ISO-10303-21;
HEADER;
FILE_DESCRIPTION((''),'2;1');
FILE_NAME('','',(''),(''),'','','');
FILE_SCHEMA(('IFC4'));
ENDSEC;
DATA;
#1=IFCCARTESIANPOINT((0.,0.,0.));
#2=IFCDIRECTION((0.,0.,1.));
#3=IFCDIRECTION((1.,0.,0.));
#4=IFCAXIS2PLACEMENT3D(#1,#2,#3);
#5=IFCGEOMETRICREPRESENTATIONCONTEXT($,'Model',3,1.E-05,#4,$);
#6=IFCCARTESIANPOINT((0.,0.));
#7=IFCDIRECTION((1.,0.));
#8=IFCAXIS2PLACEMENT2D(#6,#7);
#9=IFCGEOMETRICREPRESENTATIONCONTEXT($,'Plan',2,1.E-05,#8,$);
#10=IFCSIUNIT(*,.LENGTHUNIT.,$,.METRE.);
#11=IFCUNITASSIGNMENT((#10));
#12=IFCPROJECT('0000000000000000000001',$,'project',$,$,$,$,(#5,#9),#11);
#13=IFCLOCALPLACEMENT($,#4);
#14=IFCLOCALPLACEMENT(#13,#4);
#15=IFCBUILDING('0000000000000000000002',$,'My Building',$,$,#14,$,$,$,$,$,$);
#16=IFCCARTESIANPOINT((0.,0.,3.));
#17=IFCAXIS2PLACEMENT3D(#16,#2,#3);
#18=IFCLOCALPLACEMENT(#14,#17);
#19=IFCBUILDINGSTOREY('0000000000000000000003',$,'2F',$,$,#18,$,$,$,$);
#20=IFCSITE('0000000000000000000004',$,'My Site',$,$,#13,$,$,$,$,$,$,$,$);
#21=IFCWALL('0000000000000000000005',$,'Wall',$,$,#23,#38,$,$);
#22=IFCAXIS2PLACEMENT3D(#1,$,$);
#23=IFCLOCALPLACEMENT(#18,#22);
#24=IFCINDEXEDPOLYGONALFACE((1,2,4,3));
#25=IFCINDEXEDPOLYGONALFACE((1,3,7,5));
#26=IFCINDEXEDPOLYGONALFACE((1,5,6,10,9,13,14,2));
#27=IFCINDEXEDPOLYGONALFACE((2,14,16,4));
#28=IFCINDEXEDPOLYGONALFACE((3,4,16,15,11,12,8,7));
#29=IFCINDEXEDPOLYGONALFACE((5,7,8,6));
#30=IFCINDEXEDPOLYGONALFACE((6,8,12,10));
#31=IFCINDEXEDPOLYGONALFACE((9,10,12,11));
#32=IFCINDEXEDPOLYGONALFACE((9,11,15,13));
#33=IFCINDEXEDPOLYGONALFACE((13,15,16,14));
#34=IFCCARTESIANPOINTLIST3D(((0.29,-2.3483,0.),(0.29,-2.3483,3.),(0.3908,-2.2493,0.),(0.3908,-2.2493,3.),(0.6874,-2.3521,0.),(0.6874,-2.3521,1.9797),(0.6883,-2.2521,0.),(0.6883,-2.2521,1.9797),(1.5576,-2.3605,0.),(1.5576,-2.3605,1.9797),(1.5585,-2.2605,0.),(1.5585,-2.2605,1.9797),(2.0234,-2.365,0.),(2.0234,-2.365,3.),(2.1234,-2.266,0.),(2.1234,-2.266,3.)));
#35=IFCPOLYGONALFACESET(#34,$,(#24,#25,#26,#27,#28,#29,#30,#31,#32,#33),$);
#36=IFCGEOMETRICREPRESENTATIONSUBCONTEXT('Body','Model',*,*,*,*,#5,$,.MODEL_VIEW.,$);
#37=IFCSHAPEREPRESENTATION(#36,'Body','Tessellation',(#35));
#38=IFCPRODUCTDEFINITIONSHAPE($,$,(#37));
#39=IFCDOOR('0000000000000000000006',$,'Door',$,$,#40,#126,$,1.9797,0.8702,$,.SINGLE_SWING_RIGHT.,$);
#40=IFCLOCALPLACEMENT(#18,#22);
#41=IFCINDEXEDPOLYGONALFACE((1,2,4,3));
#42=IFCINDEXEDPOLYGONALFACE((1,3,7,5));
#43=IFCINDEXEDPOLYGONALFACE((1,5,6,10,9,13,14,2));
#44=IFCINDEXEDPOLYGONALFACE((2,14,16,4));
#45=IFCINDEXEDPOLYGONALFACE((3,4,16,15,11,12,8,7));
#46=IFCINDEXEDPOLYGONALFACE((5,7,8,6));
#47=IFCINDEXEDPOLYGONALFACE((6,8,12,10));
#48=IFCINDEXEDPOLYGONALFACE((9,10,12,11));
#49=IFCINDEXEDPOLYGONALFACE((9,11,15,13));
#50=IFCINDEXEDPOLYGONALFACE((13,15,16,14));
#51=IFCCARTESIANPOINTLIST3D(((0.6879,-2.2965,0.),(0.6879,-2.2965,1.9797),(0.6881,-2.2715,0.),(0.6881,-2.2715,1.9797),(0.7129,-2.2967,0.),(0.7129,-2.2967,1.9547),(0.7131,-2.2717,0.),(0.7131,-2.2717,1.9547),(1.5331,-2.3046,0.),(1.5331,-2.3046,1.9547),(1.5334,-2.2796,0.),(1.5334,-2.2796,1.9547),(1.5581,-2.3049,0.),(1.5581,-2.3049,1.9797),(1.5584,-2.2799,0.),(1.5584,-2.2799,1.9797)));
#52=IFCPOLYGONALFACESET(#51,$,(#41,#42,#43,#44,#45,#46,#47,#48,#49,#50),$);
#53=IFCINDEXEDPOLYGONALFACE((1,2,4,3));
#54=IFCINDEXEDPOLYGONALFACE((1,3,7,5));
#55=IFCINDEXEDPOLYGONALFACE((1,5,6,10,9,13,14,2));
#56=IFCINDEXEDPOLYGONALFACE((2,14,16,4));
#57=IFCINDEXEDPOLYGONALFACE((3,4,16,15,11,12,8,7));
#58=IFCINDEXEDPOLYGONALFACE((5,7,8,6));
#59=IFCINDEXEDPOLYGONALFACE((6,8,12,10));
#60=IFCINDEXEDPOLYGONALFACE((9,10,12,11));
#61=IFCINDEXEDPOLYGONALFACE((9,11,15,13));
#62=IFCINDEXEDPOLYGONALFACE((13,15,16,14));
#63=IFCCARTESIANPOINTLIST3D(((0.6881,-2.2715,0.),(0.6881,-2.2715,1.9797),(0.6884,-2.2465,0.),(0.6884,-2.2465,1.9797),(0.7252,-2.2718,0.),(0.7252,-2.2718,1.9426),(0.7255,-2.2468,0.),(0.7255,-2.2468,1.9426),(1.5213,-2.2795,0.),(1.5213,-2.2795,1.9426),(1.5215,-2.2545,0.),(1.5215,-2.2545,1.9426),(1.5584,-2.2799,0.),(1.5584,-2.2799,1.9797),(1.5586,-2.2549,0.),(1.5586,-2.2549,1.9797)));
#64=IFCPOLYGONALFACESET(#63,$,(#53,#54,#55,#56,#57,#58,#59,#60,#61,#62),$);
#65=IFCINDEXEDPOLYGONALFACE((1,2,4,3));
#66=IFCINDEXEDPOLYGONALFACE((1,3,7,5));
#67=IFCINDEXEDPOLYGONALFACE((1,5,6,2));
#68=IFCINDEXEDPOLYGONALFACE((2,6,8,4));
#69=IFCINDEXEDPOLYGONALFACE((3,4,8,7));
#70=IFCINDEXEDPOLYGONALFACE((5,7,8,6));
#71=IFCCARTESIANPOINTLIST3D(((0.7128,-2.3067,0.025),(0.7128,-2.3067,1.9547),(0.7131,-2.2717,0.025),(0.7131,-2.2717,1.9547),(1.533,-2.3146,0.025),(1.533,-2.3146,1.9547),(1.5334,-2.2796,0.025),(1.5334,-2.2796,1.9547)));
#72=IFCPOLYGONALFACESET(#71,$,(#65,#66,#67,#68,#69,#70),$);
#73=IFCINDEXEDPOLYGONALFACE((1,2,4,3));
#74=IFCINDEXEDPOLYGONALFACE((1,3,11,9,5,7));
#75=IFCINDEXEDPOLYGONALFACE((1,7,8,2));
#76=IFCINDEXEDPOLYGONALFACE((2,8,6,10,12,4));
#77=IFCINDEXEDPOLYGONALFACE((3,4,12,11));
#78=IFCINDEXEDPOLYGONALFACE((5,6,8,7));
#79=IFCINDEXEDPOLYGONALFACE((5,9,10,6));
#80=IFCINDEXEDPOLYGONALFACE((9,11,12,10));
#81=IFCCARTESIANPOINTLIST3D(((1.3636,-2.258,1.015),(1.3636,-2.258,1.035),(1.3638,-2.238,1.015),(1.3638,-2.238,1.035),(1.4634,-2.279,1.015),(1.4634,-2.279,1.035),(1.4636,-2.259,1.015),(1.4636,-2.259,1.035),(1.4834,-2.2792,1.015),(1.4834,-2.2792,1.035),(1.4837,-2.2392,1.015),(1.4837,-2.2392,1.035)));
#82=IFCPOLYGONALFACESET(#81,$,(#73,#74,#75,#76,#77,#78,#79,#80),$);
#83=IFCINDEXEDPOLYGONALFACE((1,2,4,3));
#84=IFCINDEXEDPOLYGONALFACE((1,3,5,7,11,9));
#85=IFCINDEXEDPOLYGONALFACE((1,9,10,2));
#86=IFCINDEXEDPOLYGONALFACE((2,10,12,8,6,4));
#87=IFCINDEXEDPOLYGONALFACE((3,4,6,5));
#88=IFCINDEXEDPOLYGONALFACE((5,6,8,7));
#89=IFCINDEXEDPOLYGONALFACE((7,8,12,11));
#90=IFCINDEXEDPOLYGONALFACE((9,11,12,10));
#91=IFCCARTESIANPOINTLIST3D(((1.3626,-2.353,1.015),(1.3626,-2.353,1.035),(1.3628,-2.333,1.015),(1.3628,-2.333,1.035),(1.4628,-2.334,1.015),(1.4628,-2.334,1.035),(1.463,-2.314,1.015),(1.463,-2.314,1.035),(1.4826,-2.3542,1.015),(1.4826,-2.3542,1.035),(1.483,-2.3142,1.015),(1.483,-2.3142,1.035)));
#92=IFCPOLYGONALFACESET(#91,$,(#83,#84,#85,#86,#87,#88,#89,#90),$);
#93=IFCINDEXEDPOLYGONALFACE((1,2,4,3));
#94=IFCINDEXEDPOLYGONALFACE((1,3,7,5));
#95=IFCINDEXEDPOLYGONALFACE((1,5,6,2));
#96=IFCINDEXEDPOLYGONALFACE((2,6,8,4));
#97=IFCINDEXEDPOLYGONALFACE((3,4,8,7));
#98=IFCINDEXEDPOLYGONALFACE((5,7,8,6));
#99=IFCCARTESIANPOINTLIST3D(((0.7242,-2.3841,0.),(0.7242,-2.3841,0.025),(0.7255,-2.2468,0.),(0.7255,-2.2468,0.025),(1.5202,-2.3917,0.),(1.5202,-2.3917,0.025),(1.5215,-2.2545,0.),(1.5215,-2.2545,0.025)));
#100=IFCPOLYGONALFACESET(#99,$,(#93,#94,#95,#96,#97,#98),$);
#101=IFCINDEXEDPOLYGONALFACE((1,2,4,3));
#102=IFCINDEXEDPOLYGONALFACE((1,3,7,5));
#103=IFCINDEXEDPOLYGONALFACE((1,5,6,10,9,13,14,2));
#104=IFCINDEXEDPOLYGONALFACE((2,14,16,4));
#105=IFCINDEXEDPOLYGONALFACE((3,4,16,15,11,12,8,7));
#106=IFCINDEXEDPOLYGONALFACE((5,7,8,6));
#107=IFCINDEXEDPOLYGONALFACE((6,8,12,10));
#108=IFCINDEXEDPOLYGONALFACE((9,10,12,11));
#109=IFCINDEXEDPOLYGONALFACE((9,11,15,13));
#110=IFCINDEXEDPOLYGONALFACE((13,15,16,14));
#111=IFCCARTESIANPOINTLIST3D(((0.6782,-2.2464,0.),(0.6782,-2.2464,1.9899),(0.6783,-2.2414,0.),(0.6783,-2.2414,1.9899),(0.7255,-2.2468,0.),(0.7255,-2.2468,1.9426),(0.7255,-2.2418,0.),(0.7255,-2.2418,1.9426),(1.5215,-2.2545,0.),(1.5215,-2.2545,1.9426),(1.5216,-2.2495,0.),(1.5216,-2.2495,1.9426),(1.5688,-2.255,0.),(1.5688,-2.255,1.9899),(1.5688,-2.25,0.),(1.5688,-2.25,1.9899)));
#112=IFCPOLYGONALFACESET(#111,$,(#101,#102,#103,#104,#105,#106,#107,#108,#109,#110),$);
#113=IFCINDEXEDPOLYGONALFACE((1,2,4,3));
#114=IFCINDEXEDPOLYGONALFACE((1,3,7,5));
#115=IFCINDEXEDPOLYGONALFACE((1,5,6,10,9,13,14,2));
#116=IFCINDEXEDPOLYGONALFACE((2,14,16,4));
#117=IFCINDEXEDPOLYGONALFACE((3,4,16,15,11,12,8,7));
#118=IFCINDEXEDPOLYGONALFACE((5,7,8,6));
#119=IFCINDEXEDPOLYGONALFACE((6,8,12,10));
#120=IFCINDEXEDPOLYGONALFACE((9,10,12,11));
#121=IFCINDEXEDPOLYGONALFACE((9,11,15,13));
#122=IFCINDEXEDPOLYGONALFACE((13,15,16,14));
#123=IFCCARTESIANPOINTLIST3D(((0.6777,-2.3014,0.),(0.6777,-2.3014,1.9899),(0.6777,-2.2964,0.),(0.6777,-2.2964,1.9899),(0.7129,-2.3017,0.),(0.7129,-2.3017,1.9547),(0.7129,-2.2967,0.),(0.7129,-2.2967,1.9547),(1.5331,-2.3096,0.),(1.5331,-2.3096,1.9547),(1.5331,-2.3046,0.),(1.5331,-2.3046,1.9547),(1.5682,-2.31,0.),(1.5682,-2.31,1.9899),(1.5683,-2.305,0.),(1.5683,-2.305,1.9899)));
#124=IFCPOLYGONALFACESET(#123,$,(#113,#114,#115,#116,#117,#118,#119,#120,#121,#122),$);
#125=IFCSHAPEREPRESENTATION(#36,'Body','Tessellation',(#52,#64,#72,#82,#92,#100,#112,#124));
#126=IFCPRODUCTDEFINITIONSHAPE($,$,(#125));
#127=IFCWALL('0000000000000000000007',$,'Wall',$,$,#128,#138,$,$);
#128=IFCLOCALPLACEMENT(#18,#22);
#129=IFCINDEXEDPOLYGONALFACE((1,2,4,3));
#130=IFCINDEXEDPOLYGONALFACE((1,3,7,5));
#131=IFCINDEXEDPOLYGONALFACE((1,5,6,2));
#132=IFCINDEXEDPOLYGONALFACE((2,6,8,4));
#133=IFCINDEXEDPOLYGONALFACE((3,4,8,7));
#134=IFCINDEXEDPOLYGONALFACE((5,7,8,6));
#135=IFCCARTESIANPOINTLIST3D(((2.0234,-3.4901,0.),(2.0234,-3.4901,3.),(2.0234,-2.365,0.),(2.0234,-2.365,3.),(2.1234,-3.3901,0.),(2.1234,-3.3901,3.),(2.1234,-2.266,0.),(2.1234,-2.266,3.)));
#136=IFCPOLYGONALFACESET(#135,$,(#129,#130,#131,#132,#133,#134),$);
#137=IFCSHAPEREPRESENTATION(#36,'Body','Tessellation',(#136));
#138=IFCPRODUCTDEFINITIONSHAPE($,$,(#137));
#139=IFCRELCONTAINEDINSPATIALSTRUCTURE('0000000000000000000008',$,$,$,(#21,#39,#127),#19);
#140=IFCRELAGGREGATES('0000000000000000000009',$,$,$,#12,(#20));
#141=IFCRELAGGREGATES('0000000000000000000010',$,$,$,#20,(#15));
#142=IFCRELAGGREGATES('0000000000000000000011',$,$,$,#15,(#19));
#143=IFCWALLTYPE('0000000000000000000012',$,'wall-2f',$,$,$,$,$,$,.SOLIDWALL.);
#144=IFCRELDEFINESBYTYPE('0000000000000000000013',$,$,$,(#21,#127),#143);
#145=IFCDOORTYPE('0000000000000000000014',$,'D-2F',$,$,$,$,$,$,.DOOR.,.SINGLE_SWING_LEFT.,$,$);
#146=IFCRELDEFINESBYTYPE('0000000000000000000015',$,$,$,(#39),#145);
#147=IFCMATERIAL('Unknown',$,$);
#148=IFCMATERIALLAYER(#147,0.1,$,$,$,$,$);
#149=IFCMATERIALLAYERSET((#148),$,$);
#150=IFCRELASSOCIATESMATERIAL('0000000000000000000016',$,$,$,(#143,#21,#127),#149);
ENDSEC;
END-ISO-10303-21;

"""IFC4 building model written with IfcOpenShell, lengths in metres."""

from ifc_helpers import new_model, entity, si_unit, frame, origin_with_axes, origin_2d_with_axis, place, context, subcontext, project, spatial, line, indexed_curve, outline, extrude, shape, source, transform, mapped, material, layer, layer_set, layer_usage, type_object, type_shapes, element, fill, save


model = new_model("IFC4")

# Units and contexts
model_context = context("Model", 3, precision=1e-05, world=origin_with_axes())
plan_context = context("Plan", 2, precision=1e-05, world=origin_2d_with_axis())
body_context_1 = subcontext(model_context, "Body", "Model", "MODEL_VIEW")
body_context_2 = subcontext(plan_context, "Body", "Plan", "PLAN_VIEW")
ifc_project = project(units=[si_unit("LENGTHUNIT", "METRE")], contexts=[model_context, plan_context])

# Site, building, storey
site_placement = place(None, origin_with_axes())
site = spatial("IfcSite", under=ifc_project, at=site_placement, Name="My Site")
building_placement = place(site_placement, origin_with_axes())
building = spatial("IfcBuilding", under=site, at=building_placement, Name="My Building")
storey_placement = place(building_placement, frame((0.0, 0.0, 3.0), z_axis=(0.0, 0.0, 1.0), x_axis=(1.0, 0.0, 0.0)))
storey = spatial("IfcBuildingStorey", under=building, at=storey_placement, Name="2F")

# Shared definitions
ifc_material = material(Name="Unknown")
ifc_layer_1 = layer(ifc_material, 0.1)
ifc_layer_set_1 = layer_set([ifc_layer_1])
wall_type_1 = type_object("IfcWallType", Name="wall-2f", PredefinedType="SOLIDWALL", material=ifc_layer_set_1)

# Wall, opening, door
ifc_layer_usage_1 = layer_usage(ifc_layer_set_1, "AXIS2", "POSITIVE", 0.0)
wall_1_placement = place(storey_placement, frame((0.29, -2.3483, 0.0), z_axis=(0.0, 0.0, 1.0), x_axis=(0.999953, -0.009661, 0.0)))
wall_1 = element("IfcWall", 1, at=wall_1_placement, inside=storey, type_object=wall_type_1, material=ifc_layer_usage_1, Name="Wall", context=body_context_1, shape_type="SweptSolid", body=[
    extrude(outline(indexed_curve([(0.0, 0.0), (0.0999, 0.1), (1.8325, 0.1), (1.7335, 0.0)], segments=[line(1, 2, 3, 4, 1)])), origin_with_axes(), (0.0, 0.0, 1.0), 3.0),
])
shared_shape_1 = source(origin_with_axes(), body_context_1, "Body", "SweptSolid", [
    extrude(outline(indexed_curve([(0.0, 0.0), (0.8702, 0.0), (0.8702, 1.9797), (0.0, 1.9797)], segments=[line(1, 2, 3, 4, 1)])), frame((0.0, -0.6, 0.0), z_axis=(0.0, -1.0, 0.0), x_axis=(1.0, 0.0, 0.0)), (0.0, 0.0, -1.0), 1.2),
])
opening_1_placement = place(wall_1_placement, frame((1.2676, 0.1057, 0.0), z_axis=(0.0, 0.0, 1.0), x_axis=(-1.0, 0.0, 0.0)))
opening_1 = element("IfcOpeningElement", 2, at=opening_1_placement, cuts=wall_1, PredefinedType="OPENING", context=body_context_1, shape_type="MappedRepresentation", body=[
    mapped(shared_shape_1, transform((0.0, 0.0, 0.0), x_axis=(1.0, 0.0, 0.0), y_axis=(0.0, 1.0, 0.0), z_axis=(0.0, 0.0, 1.0), scale=1.0)),
])
door_type_1 = type_object("IfcDoorType", Name="D-2F", OperationType="SINGLE_SWING_LEFT", PredefinedType="DOOR")
shared_shape_2 = source(origin_with_axes(), body_context_1, "Body", "SweptSolid", [
    extrude(outline(indexed_curve([(0.0, 0.0), (0.0, 1.9797), (0.8702, 1.9797), (0.8702, 0.0), (0.8452, 0.0), (0.8452, 1.9547), (0.025, 1.9547), (0.025, 0.0)], segments=[line(1, 2, 3, 4, 5, 6, 7, 8, 1)])), frame((0.0, 0.025, 0.0), z_axis=(0.0, -1.0, 0.0), x_axis=(1.0, 0.0, 0.0)), (0.0, 0.0, -1.0), 0.025),
    extrude(outline(indexed_curve([(0.0, 0.0), (0.0, 1.9797), (0.8702, 1.9797), (0.8702, 0.0), (0.8332, 0.0), (0.8332, 1.9426), (0.0371, 1.9426), (0.0371, 0.0)], segments=[line(1, 2, 3, 4, 5, 6, 7, 8, 1)])), frame((0.0, 0.0, 0.0), z_axis=(0.0, -1.0, 0.0), x_axis=(1.0, 0.0, 0.0)), (0.0, 0.0, -1.0), 0.025),
    extrude(outline(indexed_curve([(0.0, 0.0), (0.8202, 0.0), (0.8202, 0.035), (0.0, 0.035)], segments=[line(1, 2, 3, 4, 1)])), frame((0.025, 0.025, 0.025), z_axis=(0.0, 0.0, 1.0), x_axis=(1.0, 0.0, 0.0)), (0.0, 0.0, 1.0), 1.9297),
    extrude(outline(indexed_curve([(0.0, 0.0), (0.0, -0.04), (0.12, -0.04), (0.12, -0.02), (0.02, -0.02), (0.02, 0.0)], segments=[line(1, 2, 3, 4, 5, 6, 1)])), frame((0.075, 0.025, 1.015), z_axis=(0.0, 0.0, 1.0), x_axis=(1.0, 0.0, 0.0)), (0.0, 0.0, 1.0), 0.02),
    extrude(outline(indexed_curve([(0.0, 0.0), (0.0, 0.04), (0.12, 0.04), (0.12, 0.02), (0.02, 0.02), (0.02, 0.0)], segments=[line(1, 2, 3, 4, 5, 6, 1)])), frame((0.075, 0.06, 1.015), z_axis=(0.0, 0.0, 1.0), x_axis=(1.0, 0.0, 0.0)), (0.0, 0.0, 1.0), 0.02),
    extrude(outline(indexed_curve([(0.0, 0.0), (0.7961, 0.0), (0.7961, 0.1372), (0.0, 0.1372)], segments=[line(1, 2, 3, 4, 1)])), frame((0.0371, 0.0, 0.0), z_axis=(0.0, 0.0, 1.0), x_axis=(1.0, 0.0, 0.0)), (0.0, 0.0, 1.0), 0.025),
    extrude(outline(indexed_curve([(0.0, 0.0), (0.0, 1.9899), (0.8906, 1.9899), (0.8906, 0.0), (0.8433, 0.0), (0.8433, 1.9426), (0.0473, 1.9426), (0.0473, 0.0)], segments=[line(1, 2, 3, 4, 5, 6, 7, 8, 1)])), frame((-0.0102, -0.005, 0.0), z_axis=(0.0, -1.0, 0.0), x_axis=(1.0, 0.0, 0.0)), (0.0, 0.0, -1.0), 0.005),
    extrude(outline(indexed_curve([(0.0, 0.0), (0.0, 1.9899), (0.8906, 1.9899), (0.8906, 0.0), (0.8554, 0.0), (0.8554, 1.9547), (0.0352, 1.9547), (0.0352, 0.0)], segments=[line(1, 2, 3, 4, 5, 6, 7, 8, 1)])), frame((-0.0102, 0.05, 0.0), z_axis=(0.0, -1.0, 0.0), x_axis=(1.0, 0.0, 0.0)), (0.0, 0.0, -1.0), 0.005),
])
shared_shape_3 = source(origin_with_axes(), body_context_2, "Body", "Curve2D", [
    entity("IfcIndexedPolyCurve", entity("IfcCartesianPointList2D", [[0.0, 0.0], [0.0, 0.05], [0.025, 0.05], [0.025, 0.025], [0.0371, 0.025], [0.0371, 0.0]]), [entity("IfcLineIndex", [1, 2, 3, 4, 5, 6, 1])]),
    entity("IfcIndexedPolyCurve", entity("IfcCartesianPointList2D", [[0.8702, 0.0], [0.8702, 0.05], [0.8452, 0.05], [0.8452, 0.025], [0.8332, 0.025], [0.8332, 0.0]]), [entity("IfcLineIndex", [1, 2, 3, 4, 5, 6, 1])]),
    entity("IfcTrimmedCurve", entity("IfcEllipse", entity("IfcAxis2Placement2D", entity("IfcCartesianPoint", [0.8102, 0.05]), entity("IfcDirection", [1.0, 0.0])), 0.7852, 0.8202), [entity("IfcCartesianPoint", [0.8102, 0.8702])], [entity("IfcCartesianPoint", [0.025, 0.05])], True, "CARTESIAN"),
    entity("IfcIndexedPolyCurve", entity("IfcCartesianPointList2D", [[0.8452, 0.05], [0.8102, 0.05], [0.8102, 0.8702], [0.8452, 0.8702]]), [entity("IfcLineIndex", [1, 2, 3, 4, 1])]),
])
type_shapes(door_type_1, [shared_shape_2, shared_shape_3])
door_1_placement = place(opening_1_placement, frame((0.0, 0.0, 0.0), z_axis=(0.0, 0.0, 1.0), x_axis=(1.0, 0.0, 0.0)))
door_1 = element("IfcDoor", 3, at=door_1_placement, inside=storey, type_object=door_type_1, Name="Door", OperationType="SINGLE_SWING_RIGHT", OverallHeight=1.9797, OverallWidth=0.8702, shapes=[
    shape(body_context_1, "Body", "MappedRepresentation", [mapped(shared_shape_2, transform((0.0, 0.0, 0.0), x_axis=(1.0, 0.0, 0.0), y_axis=(0.0, 1.0, 0.0), z_axis=(0.0, 0.0, 1.0), scale=1.0))]),
    shape(body_context_2, "Body", "MappedRepresentation", [mapped(shared_shape_3, transform((0.0, 0.0, 0.0), x_axis=(1.0, 0.0, 0.0), y_axis=(0.0, 1.0, 0.0), z_axis=(0.0, 0.0, 1.0), scale=1.0))]),
])
fill(opening_1, door_1)

# Wall
ifc_layer_usage_2 = layer_usage(ifc_layer_set_1, "AXIS2", "POSITIVE", 0.0)
wall_2_placement = place(storey_placement, frame((2.0234, -2.365, 0.0), z_axis=(0.0, 0.0, 1.0), x_axis=(0.0, -1.0, 0.0)))
element("IfcWall", 4, at=wall_2_placement, inside=storey, type_object=wall_type_1, material=ifc_layer_usage_2, Name="Wall", context=body_context_1, shape_type="SweptSolid", body=[
    extrude(outline(indexed_curve([(0.0, 0.0), (-0.099, 0.1), (1.0251, 0.1), (1.1251, 0.0)], segments=[line(1, 2, 3, 4, 1)])), origin_with_axes(), (0.0, 0.0, 1.0), 3.0),
])

save(model, "model.ifc")
